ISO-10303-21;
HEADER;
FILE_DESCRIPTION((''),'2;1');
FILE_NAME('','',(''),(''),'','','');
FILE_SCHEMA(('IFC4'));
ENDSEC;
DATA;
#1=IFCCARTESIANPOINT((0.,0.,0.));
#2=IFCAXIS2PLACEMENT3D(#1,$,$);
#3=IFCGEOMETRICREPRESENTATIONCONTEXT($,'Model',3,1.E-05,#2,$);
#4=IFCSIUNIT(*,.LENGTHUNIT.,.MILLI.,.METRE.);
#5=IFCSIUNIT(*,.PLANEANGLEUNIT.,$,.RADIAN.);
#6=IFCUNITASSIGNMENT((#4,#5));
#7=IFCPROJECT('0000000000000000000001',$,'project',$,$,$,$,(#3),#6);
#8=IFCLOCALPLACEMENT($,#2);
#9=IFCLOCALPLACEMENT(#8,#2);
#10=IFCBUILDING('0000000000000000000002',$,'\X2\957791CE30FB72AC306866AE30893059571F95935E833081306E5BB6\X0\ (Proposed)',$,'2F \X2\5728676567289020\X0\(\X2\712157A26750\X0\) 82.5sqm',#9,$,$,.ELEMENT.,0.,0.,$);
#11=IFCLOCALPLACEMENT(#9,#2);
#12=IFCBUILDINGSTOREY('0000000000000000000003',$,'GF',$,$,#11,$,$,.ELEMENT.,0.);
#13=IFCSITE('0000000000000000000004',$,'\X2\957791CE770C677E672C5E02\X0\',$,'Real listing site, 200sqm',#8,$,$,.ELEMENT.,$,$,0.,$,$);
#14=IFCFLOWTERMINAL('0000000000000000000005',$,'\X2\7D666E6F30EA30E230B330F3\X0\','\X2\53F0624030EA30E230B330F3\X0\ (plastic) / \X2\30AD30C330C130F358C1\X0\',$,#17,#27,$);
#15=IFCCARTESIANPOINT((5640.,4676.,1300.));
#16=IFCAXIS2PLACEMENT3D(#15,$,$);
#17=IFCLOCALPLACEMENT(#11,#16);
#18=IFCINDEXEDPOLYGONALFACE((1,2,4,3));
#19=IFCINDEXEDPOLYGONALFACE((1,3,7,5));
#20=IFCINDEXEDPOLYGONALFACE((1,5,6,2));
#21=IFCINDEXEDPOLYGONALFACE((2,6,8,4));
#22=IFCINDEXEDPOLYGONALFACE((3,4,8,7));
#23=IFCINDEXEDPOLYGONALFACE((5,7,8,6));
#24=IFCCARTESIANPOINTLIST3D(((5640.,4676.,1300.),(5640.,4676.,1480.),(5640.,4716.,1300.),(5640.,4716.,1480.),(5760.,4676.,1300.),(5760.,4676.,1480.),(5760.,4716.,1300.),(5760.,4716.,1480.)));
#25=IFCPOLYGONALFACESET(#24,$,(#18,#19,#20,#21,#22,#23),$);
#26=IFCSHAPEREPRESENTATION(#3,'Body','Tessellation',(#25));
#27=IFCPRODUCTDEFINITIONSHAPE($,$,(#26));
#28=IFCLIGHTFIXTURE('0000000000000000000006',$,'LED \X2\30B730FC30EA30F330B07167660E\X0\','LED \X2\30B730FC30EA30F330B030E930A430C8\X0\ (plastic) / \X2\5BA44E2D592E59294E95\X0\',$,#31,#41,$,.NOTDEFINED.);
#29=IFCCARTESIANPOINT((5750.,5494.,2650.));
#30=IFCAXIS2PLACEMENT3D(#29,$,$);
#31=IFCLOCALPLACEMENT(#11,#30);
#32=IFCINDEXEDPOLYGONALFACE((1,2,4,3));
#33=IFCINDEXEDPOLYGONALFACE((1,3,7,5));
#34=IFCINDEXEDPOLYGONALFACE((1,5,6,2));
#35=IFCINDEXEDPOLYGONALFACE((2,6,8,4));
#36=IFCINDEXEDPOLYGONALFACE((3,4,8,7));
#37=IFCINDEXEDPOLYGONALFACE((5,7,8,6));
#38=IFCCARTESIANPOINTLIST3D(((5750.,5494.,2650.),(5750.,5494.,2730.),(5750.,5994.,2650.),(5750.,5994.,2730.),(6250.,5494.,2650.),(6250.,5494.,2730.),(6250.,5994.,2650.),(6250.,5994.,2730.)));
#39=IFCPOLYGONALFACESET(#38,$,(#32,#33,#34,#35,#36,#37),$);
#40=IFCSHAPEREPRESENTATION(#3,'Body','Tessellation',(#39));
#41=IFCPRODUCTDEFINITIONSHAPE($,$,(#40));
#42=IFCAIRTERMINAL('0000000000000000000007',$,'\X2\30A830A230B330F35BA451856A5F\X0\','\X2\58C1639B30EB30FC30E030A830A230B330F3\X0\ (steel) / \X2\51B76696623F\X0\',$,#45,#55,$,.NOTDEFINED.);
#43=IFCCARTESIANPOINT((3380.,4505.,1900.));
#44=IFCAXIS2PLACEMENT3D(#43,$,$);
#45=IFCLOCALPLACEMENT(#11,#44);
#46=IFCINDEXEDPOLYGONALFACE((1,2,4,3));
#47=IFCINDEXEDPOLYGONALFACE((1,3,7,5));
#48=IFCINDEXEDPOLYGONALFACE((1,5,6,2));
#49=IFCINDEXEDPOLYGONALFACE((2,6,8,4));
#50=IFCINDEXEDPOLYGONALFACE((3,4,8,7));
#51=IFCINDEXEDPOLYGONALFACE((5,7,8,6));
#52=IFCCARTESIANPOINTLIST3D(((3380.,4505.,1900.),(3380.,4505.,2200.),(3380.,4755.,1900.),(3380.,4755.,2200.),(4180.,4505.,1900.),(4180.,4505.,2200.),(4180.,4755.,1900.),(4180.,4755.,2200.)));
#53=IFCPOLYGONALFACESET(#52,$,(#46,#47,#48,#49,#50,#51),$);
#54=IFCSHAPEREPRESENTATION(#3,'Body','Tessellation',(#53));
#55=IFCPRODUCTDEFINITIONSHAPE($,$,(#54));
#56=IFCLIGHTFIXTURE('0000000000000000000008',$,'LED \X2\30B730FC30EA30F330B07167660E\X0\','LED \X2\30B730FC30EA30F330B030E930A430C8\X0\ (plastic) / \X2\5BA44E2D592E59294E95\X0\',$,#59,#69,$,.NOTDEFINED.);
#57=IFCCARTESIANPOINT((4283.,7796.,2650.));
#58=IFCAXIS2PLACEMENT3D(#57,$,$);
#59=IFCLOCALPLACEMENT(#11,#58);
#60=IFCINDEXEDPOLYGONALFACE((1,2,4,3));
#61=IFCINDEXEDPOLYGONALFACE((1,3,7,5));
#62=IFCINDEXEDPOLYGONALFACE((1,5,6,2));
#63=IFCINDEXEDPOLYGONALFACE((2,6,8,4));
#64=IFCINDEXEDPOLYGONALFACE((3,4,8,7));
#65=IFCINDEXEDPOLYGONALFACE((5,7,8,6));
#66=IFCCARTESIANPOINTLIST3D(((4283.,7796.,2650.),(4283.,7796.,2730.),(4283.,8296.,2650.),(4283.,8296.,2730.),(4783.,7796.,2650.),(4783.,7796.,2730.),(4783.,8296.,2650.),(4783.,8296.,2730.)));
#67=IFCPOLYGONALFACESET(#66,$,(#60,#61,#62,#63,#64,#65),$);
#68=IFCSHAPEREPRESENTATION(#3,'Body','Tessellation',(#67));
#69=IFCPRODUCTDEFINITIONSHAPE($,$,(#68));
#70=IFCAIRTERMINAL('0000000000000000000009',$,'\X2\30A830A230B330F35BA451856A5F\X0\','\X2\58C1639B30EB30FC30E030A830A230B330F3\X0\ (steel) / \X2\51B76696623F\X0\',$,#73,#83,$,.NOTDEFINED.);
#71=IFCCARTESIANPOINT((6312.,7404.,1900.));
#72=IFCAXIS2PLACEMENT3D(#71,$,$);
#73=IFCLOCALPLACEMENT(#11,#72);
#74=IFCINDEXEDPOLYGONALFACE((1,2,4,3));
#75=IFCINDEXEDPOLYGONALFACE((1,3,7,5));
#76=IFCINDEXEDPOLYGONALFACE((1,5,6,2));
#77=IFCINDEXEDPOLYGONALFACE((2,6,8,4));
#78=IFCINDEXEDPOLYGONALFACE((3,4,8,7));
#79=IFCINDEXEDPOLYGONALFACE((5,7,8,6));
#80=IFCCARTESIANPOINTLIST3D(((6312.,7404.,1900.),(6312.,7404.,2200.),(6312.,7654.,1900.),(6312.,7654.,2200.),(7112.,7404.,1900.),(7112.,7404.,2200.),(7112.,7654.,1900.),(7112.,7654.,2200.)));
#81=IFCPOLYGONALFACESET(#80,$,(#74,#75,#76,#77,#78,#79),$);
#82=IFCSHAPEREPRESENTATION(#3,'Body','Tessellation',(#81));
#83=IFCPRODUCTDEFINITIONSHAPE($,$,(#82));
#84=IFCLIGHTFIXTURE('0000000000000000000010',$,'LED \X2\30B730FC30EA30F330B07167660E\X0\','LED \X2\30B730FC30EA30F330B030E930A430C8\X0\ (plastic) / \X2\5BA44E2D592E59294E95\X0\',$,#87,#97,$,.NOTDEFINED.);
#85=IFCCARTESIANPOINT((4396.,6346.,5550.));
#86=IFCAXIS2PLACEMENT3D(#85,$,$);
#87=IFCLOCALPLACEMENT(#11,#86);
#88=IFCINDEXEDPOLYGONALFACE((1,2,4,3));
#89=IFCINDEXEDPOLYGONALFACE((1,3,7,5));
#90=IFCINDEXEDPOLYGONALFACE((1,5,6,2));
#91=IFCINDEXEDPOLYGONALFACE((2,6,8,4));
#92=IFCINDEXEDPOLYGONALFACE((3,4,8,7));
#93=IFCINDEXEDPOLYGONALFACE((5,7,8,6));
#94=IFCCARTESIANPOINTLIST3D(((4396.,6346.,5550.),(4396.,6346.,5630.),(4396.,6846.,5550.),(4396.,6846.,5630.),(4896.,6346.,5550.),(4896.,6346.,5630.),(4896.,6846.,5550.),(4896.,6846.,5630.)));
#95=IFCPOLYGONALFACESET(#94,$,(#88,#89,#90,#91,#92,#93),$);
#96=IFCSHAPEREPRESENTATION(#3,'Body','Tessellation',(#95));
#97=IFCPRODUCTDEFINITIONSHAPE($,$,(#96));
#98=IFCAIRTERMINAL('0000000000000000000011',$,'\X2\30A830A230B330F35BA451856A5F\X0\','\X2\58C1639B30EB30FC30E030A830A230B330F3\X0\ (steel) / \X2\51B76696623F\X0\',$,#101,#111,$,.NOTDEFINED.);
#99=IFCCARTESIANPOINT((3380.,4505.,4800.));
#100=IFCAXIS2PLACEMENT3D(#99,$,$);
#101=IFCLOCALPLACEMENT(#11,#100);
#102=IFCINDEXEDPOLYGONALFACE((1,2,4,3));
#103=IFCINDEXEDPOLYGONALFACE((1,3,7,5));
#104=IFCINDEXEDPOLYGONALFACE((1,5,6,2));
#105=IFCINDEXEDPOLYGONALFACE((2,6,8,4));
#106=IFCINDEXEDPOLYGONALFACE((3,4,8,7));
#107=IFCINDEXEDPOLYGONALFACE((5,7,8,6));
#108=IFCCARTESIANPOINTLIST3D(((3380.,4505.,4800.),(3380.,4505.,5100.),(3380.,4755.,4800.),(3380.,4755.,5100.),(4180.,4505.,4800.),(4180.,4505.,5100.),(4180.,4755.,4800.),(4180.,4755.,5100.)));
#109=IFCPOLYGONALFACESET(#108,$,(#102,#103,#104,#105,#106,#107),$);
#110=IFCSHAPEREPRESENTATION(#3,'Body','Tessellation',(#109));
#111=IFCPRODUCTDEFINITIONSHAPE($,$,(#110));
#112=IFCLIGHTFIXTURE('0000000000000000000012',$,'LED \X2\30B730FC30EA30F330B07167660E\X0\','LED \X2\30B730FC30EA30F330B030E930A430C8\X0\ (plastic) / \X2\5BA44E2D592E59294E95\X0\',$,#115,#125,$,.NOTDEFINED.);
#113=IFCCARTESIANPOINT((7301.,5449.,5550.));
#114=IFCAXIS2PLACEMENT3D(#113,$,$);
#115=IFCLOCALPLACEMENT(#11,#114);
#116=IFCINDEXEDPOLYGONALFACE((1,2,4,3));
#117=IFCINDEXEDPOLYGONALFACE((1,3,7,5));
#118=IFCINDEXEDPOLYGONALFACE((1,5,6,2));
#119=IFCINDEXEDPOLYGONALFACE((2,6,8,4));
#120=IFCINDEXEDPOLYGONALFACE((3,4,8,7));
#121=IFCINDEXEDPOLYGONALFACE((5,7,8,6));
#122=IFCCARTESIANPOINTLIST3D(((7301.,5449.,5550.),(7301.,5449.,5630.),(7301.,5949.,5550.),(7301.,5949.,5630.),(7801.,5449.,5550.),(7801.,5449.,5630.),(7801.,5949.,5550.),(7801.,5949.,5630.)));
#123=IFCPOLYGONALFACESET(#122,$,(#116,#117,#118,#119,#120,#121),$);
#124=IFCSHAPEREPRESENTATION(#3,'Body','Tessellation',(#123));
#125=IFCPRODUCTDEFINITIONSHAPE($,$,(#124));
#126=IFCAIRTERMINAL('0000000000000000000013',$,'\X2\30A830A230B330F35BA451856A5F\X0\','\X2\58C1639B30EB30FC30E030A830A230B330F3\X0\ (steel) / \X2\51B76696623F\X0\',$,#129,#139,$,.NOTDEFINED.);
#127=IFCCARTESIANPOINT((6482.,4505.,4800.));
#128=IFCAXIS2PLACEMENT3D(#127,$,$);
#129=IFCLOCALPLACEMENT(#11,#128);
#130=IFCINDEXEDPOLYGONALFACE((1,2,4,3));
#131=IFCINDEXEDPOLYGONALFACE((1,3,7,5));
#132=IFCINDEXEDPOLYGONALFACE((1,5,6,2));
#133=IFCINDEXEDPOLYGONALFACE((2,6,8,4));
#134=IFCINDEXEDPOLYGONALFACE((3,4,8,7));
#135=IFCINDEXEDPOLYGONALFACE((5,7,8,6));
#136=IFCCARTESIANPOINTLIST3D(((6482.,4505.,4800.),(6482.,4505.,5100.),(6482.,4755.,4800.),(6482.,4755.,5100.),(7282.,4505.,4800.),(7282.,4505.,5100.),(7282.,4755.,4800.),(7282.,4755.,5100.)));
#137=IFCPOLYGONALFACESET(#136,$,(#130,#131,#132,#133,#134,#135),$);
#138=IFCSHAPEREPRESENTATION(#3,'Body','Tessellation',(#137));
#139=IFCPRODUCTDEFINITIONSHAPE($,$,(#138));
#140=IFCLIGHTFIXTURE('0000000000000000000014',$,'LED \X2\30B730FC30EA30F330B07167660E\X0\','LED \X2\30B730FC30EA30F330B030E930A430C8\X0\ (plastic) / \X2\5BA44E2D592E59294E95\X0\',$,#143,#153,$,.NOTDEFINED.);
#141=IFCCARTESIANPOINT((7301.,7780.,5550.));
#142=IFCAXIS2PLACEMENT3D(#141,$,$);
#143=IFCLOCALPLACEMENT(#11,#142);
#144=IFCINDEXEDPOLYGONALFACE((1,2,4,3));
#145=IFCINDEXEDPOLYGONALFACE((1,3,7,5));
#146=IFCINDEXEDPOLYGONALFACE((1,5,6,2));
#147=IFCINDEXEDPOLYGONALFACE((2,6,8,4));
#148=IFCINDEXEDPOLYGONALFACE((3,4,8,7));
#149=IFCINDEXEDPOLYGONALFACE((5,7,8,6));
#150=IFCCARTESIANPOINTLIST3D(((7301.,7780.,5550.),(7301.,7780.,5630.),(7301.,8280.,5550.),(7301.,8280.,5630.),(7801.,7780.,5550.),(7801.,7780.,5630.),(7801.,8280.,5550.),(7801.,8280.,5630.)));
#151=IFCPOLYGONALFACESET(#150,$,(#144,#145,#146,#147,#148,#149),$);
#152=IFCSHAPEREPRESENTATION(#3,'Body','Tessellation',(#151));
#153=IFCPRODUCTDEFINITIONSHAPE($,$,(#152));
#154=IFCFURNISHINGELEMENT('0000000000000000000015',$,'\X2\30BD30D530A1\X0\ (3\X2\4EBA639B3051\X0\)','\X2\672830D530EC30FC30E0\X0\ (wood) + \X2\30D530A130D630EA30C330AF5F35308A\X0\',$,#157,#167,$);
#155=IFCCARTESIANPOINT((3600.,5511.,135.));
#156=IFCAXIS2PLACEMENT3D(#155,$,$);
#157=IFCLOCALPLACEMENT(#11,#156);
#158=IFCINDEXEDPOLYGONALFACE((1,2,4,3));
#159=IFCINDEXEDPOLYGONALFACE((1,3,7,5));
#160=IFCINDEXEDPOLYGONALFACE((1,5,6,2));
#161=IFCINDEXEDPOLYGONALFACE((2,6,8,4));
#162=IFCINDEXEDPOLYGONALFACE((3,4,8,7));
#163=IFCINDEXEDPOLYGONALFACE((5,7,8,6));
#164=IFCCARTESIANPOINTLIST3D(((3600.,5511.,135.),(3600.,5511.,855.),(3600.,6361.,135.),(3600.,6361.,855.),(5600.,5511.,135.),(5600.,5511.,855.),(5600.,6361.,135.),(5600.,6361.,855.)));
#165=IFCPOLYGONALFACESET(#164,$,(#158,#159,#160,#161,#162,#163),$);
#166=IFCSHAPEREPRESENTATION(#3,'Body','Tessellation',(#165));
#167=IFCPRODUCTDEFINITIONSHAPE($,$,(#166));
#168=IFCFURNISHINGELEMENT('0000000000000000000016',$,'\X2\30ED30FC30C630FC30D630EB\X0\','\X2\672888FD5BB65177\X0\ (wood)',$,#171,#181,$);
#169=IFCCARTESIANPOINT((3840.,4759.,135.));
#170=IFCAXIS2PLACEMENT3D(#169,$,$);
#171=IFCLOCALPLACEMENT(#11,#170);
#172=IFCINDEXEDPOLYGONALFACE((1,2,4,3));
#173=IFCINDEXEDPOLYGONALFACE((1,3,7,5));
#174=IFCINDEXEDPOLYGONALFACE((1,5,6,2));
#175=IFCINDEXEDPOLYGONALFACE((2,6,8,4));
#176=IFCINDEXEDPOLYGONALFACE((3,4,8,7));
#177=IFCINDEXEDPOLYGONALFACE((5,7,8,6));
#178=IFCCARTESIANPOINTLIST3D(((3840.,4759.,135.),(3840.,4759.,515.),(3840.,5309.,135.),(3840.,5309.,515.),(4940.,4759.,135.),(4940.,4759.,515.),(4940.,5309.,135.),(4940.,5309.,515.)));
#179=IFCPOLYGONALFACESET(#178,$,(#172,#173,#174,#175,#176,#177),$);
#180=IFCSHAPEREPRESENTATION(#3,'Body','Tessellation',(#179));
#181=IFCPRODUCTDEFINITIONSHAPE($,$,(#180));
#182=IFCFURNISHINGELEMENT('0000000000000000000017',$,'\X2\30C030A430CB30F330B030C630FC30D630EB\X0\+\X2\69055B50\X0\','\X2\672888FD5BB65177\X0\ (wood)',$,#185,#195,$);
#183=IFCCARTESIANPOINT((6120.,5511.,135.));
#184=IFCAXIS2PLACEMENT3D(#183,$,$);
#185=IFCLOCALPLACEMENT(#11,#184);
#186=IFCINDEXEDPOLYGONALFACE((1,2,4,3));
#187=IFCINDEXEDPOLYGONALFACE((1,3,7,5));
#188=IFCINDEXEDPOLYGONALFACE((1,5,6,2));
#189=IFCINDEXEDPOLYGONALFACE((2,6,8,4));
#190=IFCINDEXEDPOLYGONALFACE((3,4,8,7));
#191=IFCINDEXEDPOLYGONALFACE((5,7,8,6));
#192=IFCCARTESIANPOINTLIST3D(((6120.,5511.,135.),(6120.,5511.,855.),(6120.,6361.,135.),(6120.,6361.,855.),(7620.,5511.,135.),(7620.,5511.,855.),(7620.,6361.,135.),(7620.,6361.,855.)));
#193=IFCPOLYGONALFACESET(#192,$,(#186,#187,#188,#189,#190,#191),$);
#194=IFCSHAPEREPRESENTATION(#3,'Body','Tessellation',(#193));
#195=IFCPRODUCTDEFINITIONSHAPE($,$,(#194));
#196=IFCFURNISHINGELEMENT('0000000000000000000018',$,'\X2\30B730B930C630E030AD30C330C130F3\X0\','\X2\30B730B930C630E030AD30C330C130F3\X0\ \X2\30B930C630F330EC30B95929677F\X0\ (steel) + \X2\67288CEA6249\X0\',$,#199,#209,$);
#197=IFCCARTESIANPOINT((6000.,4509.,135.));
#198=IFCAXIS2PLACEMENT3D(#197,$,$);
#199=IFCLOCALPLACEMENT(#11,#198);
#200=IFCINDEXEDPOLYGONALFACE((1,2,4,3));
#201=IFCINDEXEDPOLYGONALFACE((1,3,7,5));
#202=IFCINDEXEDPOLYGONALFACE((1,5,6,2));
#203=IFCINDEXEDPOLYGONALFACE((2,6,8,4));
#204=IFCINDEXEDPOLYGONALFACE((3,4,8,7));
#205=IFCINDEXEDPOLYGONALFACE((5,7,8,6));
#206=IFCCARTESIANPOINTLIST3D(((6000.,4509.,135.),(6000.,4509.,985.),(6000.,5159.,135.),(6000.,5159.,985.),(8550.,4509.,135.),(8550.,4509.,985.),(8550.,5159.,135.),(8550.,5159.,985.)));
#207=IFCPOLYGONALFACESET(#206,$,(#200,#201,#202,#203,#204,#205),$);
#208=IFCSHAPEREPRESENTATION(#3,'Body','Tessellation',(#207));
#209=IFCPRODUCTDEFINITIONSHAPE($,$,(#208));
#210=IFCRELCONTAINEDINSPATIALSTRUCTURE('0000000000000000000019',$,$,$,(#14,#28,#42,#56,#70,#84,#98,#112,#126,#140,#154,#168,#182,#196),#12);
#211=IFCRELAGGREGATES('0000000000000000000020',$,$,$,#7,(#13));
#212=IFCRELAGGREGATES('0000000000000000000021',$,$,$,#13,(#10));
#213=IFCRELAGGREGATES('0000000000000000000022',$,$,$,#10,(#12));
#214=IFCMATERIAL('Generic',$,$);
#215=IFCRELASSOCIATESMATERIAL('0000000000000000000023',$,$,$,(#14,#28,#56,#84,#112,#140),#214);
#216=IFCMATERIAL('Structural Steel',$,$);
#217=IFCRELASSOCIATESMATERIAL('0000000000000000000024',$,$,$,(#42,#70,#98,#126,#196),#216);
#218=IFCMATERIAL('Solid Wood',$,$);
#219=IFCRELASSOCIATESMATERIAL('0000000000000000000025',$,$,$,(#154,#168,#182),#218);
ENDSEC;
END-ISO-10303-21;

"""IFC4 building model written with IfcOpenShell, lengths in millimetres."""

from ifc_helpers import new_model, si_unit, frame, frame_2d, origin, place, context, project, spatial, rectangle, extrude, material, element, save


model = new_model("IFC4")

# Units and contexts
model_context = context("Model", 3, precision=1e-05, world=origin())
ifc_project = project(units=[si_unit("LENGTHUNIT", "METRE", prefix="MILLI"), si_unit("PLANEANGLEUNIT", "RADIAN")], contexts=[model_context])

# Site, building, storey
site_placement = place(None, origin())
site = spatial("IfcSite", under=ifc_project, at=site_placement, Name="長野県松本市", ObjectType="Real listing site, 200sqm", CompositionType="ELEMENT", RefElevation=0.0)
building_placement = place(site_placement, origin())
building = spatial("IfcBuilding", under=site, at=building_placement, Name="長野・犬と暮らす土間広めの家 (Proposed)", ObjectType="2F 在来木造(無垢材) 82.5sqm", CompositionType="ELEMENT", ElevationOfRefHeight=0.0, ElevationOfTerrain=0.0)
storey_placement = place(building_placement, origin())
storey = spatial("IfcBuildingStorey", under=building, at=storey_placement, Name="GF", CompositionType="ELEMENT", Elevation=0.0)

# Shared definitions
ifc_material_1 = material(Name="Solid Wood")

# Shared definitions
ifc_material_2 = material(Name="Structural Steel")

# Flow terminal
ifc_material_3 = material(Name="Generic")
flow_terminal_1_placement = place(storey_placement, frame((5640.0, 4676.0, 1300.0)))
element("IfcFlowTerminal", 1, at=flow_terminal_1_placement, inside=storey, material=ifc_material_3, Name="給湯リモコン", Description="台所リモコン (plastic) / キッチン壁", context=model_context, shape_type="SweptSolid", body=[
    extrude(rectangle(XDim=120.0, YDim=40.0, at=frame_2d((60.0, 20.0))), frame((5640.0, 4676.0, 1300.0)), (0.0, 0.0, 1.0), 180.0),
])

# Light fixture
light_fixture_1_placement = place(storey_placement, frame((5750.0, 5494.0, 2650.0)))
element("IfcLightFixture", 2, at=light_fixture_1_placement, inside=storey, material=ifc_material_3, Name="LED シーリング照明", Description="LED シーリングライト (plastic) / 室中央天井", PredefinedType="NOTDEFINED", context=model_context, shape_type="SweptSolid", body=[
    extrude(rectangle(XDim=500.0, YDim=500.0, at=frame_2d((250.0, 250.0))), frame((5750.0, 5494.0, 2650.0)), (0.0, 0.0, 1.0), 80.0),
])

# Air terminal
air_terminal_1_placement = place(storey_placement, frame((3380.0, 4505.0, 1900.0)))
element("IfcAirTerminal", 3, at=air_terminal_1_placement, inside=storey, material=ifc_material_2, Name="エアコン室内機", Description="壁掛ルームエアコン (steel) / 冷暖房", PredefinedType="NOTDEFINED", context=model_context, shape_type="SweptSolid", body=[
    extrude(rectangle(XDim=800.0, YDim=250.0, at=frame_2d((400.0, 125.0))), frame((3380.0, 4505.0, 1900.0)), (0.0, 0.0, 1.0), 300.0),
])

# Light fixture
light_fixture_2_placement = place(storey_placement, frame((4283.0, 7796.0, 2650.0)))
element("IfcLightFixture", 4, at=light_fixture_2_placement, inside=storey, material=ifc_material_3, Name="LED シーリング照明", Description="LED シーリングライト (plastic) / 室中央天井", PredefinedType="NOTDEFINED", context=model_context, shape_type="SweptSolid", body=[
    extrude(rectangle(XDim=500.0, YDim=500.0, at=frame_2d((250.0, 250.0))), frame((4283.0, 7796.0, 2650.0)), (0.0, 0.0, 1.0), 80.0),
])

# Air terminal
air_terminal_2_placement = place(storey_placement, frame((6312.0, 7404.0, 1900.0)))
element("IfcAirTerminal", 5, at=air_terminal_2_placement, inside=storey, material=ifc_material_2, Name="エアコン室内機", Description="壁掛ルームエアコン (steel) / 冷暖房", PredefinedType="NOTDEFINED", context=model_context, shape_type="SweptSolid", body=[
    extrude(rectangle(XDim=800.0, YDim=250.0, at=frame_2d((400.0, 125.0))), frame((6312.0, 7404.0, 1900.0)), (0.0, 0.0, 1.0), 300.0),
])

# Light fixture
light_fixture_3_placement = place(storey_placement, frame((4396.0, 6346.0, 5550.0)))
element("IfcLightFixture", 6, at=light_fixture_3_placement, inside=storey, material=ifc_material_3, Name="LED シーリング照明", Description="LED シーリングライト (plastic) / 室中央天井", PredefinedType="NOTDEFINED", context=model_context, shape_type="SweptSolid", body=[
    extrude(rectangle(XDim=500.0, YDim=500.0, at=frame_2d((250.0, 250.0))), frame((4396.0, 6346.0, 5550.0)), (0.0, 0.0, 1.0), 80.0),
])

# Air terminal
air_terminal_3_placement = place(storey_placement, frame((3380.0, 4505.0, 4800.0)))
element("IfcAirTerminal", 7, at=air_terminal_3_placement, inside=storey, material=ifc_material_2, Name="エアコン室内機", Description="壁掛ルームエアコン (steel) / 冷暖房", PredefinedType="NOTDEFINED", context=model_context, shape_type="SweptSolid", body=[
    extrude(rectangle(XDim=800.0, YDim=250.0, at=frame_2d((400.0, 125.0))), frame((3380.0, 4505.0, 4800.0)), (0.0, 0.0, 1.0), 300.0),
])

# Light fixture
light_fixture_4_placement = place(storey_placement, frame((7301.0, 5449.0, 5550.0)))
element("IfcLightFixture", 8, at=light_fixture_4_placement, inside=storey, material=ifc_material_3, Name="LED シーリング照明", Description="LED シーリングライト (plastic) / 室中央天井", PredefinedType="NOTDEFINED", context=model_context, shape_type="SweptSolid", body=[
    extrude(rectangle(XDim=500.0, YDim=500.0, at=frame_2d((250.0, 250.0))), frame((7301.0, 5449.0, 5550.0)), (0.0, 0.0, 1.0), 80.0),
])

# Air terminal
air_terminal_4_placement = place(storey_placement, frame((6482.0, 4505.0, 4800.0)))
element("IfcAirTerminal", 9, at=air_terminal_4_placement, inside=storey, material=ifc_material_2, Name="エアコン室内機", Description="壁掛ルームエアコン (steel) / 冷暖房", PredefinedType="NOTDEFINED", context=model_context, shape_type="SweptSolid", body=[
    extrude(rectangle(XDim=800.0, YDim=250.0, at=frame_2d((400.0, 125.0))), frame((6482.0, 4505.0, 4800.0)), (0.0, 0.0, 1.0), 300.0),
])

# Light fixture
light_fixture_5_placement = place(storey_placement, frame((7301.0, 7780.0, 5550.0)))
element("IfcLightFixture", 10, at=light_fixture_5_placement, inside=storey, material=ifc_material_3, Name="LED シーリング照明", Description="LED シーリングライト (plastic) / 室中央天井", PredefinedType="NOTDEFINED", context=model_context, shape_type="SweptSolid", body=[
    extrude(rectangle(XDim=500.0, YDim=500.0, at=frame_2d((250.0, 250.0))), frame((7301.0, 7780.0, 5550.0)), (0.0, 0.0, 1.0), 80.0),
])

# Furnishing elements
furnishing_1_placement = place(storey_placement, frame((3600.0, 5511.0, 135.0)))
element("IfcFurnishingElement", 11, at=furnishing_1_placement, inside=storey, material=ifc_material_1, Name="ソファ (3人掛け)", Description="木フレーム (wood) + ファブリック張り", context=model_context, shape_type="SweptSolid", body=[
    extrude(rectangle(XDim=2000.0, YDim=850.0, at=frame_2d((1000.0, 425.0))), frame((3600.0, 5511.0, 135.0)), (0.0, 0.0, 1.0), 720.0),
])
furnishing_2_placement = place(storey_placement, frame((3840.0, 4759.0, 135.0)))
element("IfcFurnishingElement", 12, at=furnishing_2_placement, inside=storey, material=ifc_material_1, Name="ローテーブル", Description="木製家具 (wood)", context=model_context, shape_type="SweptSolid", body=[
    extrude(rectangle(XDim=1100.0, YDim=550.0, at=frame_2d((550.0, 275.0))), frame((3840.0, 4759.0, 135.0)), (0.0, 0.0, 1.0), 380.0),
])
furnishing_3_placement = place(storey_placement, frame((6120.0, 5511.0, 135.0)))
element("IfcFurnishingElement", 13, at=furnishing_3_placement, inside=storey, material=ifc_material_1, Name="ダイニングテーブル+椅子", Description="木製家具 (wood)", context=model_context, shape_type="SweptSolid", body=[
    extrude(rectangle(XDim=1500.0, YDim=850.0, at=frame_2d((750.0, 425.0))), frame((6120.0, 5511.0, 135.0)), (0.0, 0.0, 1.0), 720.0),
])
furnishing_4_placement = place(storey_placement, frame((6000.0, 4509.0, 135.0)))
element("IfcFurnishingElement", 14, at=furnishing_4_placement, inside=storey, material=ifc_material_2, Name="システムキッチン", Description="システムキッチン ステンレス天板 (steel) + 木質扉", context=model_context, shape_type="SweptSolid", body=[
    extrude(rectangle(XDim=2550.0, YDim=650.0, at=frame_2d((1275.0, 325.0))), frame((6000.0, 4509.0, 135.0)), (0.0, 0.0, 1.0), 850.0),
])

save(model, "model.ifc")
